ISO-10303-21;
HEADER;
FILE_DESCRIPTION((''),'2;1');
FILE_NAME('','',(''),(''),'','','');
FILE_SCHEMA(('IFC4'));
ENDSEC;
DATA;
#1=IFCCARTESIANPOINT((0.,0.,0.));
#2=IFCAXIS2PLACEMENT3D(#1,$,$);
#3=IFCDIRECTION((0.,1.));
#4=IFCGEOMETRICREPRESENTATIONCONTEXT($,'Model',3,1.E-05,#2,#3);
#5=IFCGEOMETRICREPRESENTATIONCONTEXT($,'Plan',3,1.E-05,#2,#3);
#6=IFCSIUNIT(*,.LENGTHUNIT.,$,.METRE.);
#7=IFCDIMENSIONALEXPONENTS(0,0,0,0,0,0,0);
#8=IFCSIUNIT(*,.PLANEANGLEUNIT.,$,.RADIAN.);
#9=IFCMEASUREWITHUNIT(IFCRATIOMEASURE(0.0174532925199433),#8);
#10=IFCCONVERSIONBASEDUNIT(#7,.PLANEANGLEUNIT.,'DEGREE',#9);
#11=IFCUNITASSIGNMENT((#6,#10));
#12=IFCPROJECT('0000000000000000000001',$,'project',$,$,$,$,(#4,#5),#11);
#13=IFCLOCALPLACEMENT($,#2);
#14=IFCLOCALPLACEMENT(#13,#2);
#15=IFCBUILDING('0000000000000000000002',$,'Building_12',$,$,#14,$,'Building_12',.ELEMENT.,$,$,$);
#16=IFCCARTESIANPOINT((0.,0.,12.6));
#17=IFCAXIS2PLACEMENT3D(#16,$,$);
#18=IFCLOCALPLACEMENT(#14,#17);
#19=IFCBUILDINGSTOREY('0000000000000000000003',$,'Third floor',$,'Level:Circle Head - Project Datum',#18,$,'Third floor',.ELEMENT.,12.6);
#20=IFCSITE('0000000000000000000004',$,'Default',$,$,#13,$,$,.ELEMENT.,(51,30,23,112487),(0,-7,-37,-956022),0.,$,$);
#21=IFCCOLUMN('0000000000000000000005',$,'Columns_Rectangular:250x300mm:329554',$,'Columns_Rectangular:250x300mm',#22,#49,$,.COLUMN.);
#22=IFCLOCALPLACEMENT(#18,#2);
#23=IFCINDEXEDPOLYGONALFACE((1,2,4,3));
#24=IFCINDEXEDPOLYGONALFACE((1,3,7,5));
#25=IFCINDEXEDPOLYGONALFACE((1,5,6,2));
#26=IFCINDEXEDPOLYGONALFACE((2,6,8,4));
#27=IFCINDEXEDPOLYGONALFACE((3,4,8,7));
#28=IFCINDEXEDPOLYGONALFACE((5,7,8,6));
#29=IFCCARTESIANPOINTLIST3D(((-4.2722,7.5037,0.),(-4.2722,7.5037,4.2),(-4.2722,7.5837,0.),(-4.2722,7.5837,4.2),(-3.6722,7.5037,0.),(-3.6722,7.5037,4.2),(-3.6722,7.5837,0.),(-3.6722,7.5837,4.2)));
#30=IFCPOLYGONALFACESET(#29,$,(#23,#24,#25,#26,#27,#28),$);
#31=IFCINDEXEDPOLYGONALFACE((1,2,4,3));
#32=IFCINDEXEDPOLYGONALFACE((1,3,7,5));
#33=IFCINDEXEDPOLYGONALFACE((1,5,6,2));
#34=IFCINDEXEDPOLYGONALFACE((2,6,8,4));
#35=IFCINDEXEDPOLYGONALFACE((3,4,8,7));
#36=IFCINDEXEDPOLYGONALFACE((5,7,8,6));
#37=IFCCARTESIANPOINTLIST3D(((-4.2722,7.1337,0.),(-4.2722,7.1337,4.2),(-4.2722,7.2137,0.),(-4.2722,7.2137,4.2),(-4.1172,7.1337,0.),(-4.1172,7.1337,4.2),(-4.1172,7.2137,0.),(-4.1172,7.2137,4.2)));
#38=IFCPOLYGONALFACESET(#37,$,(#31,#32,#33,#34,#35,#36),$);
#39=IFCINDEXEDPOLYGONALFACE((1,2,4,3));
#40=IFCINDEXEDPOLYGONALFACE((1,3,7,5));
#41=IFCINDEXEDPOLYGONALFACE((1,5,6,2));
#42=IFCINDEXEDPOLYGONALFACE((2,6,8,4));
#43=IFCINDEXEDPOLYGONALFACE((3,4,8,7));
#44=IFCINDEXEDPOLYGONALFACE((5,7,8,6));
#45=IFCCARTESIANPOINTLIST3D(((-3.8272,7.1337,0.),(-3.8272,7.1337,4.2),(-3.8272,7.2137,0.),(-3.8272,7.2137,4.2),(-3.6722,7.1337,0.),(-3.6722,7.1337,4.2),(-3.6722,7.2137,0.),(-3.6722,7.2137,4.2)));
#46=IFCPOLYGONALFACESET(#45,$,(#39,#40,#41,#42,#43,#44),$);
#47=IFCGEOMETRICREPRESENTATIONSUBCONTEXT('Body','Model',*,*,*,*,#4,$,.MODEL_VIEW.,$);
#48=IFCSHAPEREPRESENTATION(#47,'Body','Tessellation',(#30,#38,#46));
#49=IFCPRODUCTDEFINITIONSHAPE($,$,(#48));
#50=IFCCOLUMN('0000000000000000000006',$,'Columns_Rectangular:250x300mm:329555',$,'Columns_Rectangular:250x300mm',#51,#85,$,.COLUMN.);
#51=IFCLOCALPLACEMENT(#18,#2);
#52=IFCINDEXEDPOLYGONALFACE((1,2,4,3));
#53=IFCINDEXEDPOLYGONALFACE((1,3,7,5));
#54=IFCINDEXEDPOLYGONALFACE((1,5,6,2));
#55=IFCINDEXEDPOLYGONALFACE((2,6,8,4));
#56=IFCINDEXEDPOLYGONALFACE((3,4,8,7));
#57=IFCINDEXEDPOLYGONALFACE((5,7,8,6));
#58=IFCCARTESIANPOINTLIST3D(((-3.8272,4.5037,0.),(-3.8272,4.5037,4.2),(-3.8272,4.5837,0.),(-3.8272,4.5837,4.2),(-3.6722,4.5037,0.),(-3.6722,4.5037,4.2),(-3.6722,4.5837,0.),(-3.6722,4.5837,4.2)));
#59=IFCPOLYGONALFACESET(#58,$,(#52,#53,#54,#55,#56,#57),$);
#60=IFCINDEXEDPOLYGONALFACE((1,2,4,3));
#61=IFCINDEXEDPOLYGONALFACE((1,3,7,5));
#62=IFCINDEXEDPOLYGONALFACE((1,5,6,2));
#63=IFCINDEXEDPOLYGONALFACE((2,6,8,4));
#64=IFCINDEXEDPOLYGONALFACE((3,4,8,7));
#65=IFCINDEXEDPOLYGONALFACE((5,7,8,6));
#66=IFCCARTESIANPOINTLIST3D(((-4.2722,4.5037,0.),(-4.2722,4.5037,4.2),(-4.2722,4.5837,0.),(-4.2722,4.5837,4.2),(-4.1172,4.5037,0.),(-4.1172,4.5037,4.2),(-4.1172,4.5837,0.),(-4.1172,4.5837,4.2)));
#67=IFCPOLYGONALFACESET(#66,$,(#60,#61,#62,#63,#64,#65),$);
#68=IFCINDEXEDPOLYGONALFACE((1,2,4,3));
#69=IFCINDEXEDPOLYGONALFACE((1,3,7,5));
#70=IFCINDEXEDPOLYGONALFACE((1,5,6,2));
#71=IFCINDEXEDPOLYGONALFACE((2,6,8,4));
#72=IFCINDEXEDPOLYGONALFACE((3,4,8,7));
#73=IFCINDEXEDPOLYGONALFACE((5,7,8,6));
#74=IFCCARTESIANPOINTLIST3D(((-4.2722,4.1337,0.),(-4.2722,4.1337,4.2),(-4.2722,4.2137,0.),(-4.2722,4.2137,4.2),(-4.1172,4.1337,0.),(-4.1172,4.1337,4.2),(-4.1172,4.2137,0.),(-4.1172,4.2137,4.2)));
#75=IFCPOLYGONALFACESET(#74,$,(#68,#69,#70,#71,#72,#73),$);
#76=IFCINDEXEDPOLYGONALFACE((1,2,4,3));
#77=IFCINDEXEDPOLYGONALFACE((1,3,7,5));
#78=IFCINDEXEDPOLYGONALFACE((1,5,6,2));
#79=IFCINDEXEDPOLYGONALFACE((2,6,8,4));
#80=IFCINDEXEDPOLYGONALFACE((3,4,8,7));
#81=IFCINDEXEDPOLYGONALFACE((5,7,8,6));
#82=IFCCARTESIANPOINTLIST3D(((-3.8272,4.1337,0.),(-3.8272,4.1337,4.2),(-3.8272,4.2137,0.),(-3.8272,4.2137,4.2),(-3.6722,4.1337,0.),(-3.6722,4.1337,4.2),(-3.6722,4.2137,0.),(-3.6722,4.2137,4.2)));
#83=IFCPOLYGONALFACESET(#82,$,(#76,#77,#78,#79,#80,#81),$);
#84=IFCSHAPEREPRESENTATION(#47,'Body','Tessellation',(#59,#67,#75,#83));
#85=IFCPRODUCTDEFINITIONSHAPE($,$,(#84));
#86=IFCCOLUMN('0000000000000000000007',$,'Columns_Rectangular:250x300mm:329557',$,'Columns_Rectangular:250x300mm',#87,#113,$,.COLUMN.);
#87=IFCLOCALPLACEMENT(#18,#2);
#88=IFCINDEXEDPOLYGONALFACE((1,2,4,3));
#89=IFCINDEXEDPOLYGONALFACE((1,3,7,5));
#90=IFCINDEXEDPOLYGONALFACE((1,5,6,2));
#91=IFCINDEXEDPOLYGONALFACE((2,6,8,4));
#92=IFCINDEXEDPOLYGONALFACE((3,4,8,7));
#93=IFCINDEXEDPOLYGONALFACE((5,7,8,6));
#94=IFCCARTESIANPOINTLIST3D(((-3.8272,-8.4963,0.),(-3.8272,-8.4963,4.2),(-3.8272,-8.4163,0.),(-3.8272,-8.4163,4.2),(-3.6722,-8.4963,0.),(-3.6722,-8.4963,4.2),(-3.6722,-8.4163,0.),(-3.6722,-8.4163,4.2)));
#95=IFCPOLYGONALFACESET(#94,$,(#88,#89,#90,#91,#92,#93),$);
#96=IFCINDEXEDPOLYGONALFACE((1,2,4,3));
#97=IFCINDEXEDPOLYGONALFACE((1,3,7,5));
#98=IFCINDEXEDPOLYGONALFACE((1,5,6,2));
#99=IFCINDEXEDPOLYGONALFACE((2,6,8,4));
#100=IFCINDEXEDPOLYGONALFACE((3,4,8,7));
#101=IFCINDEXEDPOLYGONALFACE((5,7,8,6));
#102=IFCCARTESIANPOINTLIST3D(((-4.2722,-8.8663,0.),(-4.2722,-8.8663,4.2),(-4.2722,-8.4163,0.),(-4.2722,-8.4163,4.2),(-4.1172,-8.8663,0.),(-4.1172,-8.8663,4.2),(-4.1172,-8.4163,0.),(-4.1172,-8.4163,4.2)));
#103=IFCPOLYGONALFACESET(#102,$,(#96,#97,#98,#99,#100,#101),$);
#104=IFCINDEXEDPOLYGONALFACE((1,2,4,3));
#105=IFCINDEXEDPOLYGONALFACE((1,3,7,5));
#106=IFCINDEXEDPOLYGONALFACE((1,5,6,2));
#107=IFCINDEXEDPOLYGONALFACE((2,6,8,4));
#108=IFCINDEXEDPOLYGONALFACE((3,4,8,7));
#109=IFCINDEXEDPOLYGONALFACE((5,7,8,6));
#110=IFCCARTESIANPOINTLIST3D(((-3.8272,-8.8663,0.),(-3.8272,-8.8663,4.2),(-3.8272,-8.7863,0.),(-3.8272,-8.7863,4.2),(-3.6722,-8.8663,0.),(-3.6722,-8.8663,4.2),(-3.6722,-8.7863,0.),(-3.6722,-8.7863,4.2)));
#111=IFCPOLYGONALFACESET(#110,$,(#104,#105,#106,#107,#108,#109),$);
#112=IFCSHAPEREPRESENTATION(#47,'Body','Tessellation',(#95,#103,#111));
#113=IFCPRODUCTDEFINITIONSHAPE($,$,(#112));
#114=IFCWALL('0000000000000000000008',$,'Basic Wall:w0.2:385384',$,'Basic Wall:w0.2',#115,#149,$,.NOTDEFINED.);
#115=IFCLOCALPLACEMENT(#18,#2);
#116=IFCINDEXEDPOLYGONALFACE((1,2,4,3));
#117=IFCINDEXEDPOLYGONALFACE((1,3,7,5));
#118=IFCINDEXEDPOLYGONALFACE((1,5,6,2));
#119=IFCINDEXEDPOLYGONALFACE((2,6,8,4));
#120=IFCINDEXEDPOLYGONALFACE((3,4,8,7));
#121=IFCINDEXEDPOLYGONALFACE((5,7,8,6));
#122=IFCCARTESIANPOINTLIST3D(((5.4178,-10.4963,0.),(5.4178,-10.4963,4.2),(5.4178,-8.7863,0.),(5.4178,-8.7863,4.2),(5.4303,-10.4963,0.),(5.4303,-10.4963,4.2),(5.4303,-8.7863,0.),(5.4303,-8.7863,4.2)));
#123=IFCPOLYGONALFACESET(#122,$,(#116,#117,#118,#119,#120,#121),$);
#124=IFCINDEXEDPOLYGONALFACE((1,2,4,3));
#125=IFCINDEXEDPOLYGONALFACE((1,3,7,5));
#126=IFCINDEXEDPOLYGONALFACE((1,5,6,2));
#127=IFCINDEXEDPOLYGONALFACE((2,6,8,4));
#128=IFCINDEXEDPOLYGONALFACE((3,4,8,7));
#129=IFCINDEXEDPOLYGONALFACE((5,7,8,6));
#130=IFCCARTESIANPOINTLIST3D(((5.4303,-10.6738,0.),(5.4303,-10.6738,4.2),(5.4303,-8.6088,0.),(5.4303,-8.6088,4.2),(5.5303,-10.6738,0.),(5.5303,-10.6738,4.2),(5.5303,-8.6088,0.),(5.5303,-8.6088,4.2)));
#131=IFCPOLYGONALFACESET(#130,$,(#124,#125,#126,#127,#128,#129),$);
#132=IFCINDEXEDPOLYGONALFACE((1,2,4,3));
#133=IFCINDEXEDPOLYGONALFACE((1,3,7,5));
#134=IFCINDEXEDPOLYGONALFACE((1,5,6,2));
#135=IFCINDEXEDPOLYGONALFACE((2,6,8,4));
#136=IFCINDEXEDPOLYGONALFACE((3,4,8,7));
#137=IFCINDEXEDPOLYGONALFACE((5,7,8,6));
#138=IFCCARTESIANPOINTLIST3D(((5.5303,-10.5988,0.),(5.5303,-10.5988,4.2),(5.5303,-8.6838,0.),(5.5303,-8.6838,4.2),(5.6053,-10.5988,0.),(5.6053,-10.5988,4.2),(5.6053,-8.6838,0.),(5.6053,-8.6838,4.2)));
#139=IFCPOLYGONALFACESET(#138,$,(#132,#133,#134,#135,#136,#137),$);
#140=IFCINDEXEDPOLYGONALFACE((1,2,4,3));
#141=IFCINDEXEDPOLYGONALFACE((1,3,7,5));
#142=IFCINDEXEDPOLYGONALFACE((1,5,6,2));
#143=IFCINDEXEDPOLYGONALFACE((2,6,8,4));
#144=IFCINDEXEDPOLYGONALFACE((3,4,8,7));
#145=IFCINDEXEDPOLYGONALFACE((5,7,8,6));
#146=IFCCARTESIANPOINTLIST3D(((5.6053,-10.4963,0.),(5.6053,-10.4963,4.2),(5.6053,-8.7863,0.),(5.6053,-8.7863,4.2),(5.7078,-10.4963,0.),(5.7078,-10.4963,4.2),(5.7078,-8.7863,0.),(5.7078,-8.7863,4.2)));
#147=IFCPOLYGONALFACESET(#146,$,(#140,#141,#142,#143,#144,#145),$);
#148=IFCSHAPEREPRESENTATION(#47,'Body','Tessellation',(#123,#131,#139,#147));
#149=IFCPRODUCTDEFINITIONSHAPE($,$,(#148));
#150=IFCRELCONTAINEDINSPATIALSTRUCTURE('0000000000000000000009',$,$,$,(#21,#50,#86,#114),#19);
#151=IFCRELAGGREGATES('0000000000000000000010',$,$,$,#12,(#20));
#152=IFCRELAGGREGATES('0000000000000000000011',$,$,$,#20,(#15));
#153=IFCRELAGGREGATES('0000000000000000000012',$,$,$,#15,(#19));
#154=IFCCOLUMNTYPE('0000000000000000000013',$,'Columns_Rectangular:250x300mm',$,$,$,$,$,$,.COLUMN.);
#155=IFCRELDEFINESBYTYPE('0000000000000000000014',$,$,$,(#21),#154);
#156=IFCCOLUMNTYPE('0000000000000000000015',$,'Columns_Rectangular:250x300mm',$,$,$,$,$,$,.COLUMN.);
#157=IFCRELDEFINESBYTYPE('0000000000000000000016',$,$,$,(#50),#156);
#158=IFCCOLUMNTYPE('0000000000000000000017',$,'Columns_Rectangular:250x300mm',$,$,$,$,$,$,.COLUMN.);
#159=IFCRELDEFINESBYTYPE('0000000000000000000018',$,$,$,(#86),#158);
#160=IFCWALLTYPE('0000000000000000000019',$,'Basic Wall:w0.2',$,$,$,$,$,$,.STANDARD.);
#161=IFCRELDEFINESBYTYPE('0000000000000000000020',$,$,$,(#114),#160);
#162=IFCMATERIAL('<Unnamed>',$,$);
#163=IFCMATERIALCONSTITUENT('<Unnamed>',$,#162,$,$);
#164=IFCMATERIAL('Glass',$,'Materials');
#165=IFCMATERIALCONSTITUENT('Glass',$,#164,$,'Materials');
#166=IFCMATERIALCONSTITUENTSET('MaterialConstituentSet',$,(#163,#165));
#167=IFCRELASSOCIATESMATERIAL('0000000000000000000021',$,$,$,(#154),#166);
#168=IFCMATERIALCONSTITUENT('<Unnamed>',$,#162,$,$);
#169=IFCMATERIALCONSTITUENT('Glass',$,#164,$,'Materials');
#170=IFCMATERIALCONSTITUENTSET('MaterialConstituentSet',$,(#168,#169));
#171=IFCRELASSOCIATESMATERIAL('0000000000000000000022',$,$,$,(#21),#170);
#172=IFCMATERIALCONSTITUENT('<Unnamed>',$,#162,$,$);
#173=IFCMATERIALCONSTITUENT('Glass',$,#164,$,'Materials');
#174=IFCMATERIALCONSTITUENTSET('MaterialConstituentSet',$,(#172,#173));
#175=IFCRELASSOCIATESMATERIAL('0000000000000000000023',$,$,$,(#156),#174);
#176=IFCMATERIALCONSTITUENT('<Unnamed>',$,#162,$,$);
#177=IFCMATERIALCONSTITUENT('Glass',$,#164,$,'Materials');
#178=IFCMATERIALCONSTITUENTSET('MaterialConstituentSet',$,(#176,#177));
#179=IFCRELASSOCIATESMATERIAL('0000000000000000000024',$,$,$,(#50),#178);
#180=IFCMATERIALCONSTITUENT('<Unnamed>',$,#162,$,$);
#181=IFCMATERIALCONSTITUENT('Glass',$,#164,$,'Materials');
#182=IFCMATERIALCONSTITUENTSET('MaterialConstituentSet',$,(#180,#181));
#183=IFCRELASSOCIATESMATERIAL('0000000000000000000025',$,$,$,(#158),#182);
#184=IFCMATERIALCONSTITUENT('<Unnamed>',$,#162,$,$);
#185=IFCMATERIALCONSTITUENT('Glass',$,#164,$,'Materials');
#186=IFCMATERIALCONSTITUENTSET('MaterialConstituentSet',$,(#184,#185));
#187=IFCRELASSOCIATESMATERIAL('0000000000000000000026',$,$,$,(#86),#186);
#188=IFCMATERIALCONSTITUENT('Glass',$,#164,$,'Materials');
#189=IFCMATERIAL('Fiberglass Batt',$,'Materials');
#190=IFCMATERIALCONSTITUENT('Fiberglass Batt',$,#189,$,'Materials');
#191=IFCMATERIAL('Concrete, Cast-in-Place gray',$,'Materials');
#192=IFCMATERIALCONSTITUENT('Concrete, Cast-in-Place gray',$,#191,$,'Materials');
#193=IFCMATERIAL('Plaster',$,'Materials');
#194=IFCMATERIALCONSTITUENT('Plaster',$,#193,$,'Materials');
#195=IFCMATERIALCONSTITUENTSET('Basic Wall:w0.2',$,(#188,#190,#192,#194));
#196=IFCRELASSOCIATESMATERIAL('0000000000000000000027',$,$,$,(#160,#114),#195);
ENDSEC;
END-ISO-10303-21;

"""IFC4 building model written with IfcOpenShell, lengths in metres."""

from ifc_helpers import new_model, entity, si_unit, converted_unit, direction, frame, origin, place, context, subcontext, project, spatial, indexed_curve, outline, extrude, source, transform, mapped, material, constituent, constituent_set, type_object, type_shapes, element, save


model = new_model("IFC4")

# Units and contexts
model_context = context("Model", 3, precision=1e-05, world=origin(), true_north=direction((0.0, 1.0)))
plan_context = context("Plan", 3, precision=1e-05, world=origin(), true_north=direction((0.0, 1.0)))
body_context = subcontext(model_context, "Body", "Model", "MODEL_VIEW")
ifc_project = project(units=[si_unit("LENGTHUNIT", "METRE"), converted_unit("PLANEANGLEUNIT", "DEGREE", entity("IfcRatioMeasure", 0.0174532925199433), si_unit("PLANEANGLEUNIT", "RADIAN"), dimensions=[0, 0, 0, 0, 0, 0, 0])], contexts=[model_context, plan_context])

# Site, building, storey
site_placement = place(None, origin())
site = spatial("IfcSite", under=ifc_project, at=site_placement, Name="Default", CompositionType="ELEMENT", RefLatitude=(51, 30, 23, 112487), RefLongitude=(0, -7, -37, -956022), RefElevation=0.0)
building_placement = place(site_placement, origin())
building = spatial("IfcBuilding", under=site, at=building_placement, Name="Building_12", LongName="Building_12", CompositionType="ELEMENT")
storey_placement = place(building_placement, frame((0.0, 0.0, 12.6)))
storey = spatial("IfcBuildingStorey", under=building, at=storey_placement, Name="Third floor", ObjectType="Level:Circle Head - Project Datum", LongName="Third floor", CompositionType="ELEMENT", Elevation=12.6)

# Columns
ifc_material_1 = material(Name="<Unnamed>")
ifc_material_2 = material(Name="Plaster", Category="Materials")
ifc_constituent_1 = constituent(ifc_material_1, Name="<Unnamed>")
ifc_material_3 = material(Name="Glass", Category="Materials")
ifc_constituent_2 = constituent(ifc_material_3, Name="Glass", Category="Materials")
ifc_constituent_set_1 = constituent_set(constituents=[ifc_constituent_1, ifc_constituent_2], Name="MaterialConstituentSet")
ifc_constituent_3 = constituent(ifc_material_1, Name="<Unnamed>")
ifc_constituent_4 = constituent(ifc_material_3, Name="Glass", Category="Materials")
ifc_constituent_set_2 = constituent_set(constituents=[ifc_constituent_3, ifc_constituent_4], Name="MaterialConstituentSet")
column_type_1 = type_object("IfcColumnType", Name="Columns_Rectangular:250x300mm", PredefinedType="COLUMN", material=ifc_constituent_set_2)
shared_shape_1 = source(origin(), body_context, "Body", "SweptSolid", [
    extrude(outline(indexed_curve([(-0.04, -0.3), (0.04, -0.3), (0.04, 0.3), (-0.04, 0.3), (-0.04, -0.3)], self_intersect=False)), frame((-3.9722, 7.5437, 12.6), z_axis=(0.0, 0.0, 1.0), x_axis=(0.0, -1.0, 0.0)), (0.0, 0.0, 1.0), 4.2),
    extrude(outline(indexed_curve([(-0.04, -0.0775), (0.04, -0.0775), (0.04, 0.0775), (-0.04, 0.0775), (-0.04, -0.0775)], self_intersect=False)), frame((-4.1947, 7.1737, 12.6), z_axis=(0.0, 0.0, 1.0), x_axis=(0.0, -1.0, 0.0)), (0.0, 0.0, 1.0), 4.2),
    extrude(outline(indexed_curve([(-0.04, -0.0775), (0.04, -0.0775), (0.04, 0.0775), (-0.04, 0.0775), (-0.04, -0.0775)], self_intersect=False)), frame((-3.7497, 7.1737, 12.6), z_axis=(0.0, 0.0, 1.0), x_axis=(0.0, -1.0, 0.0)), (0.0, 0.0, 1.0), 4.2),
])
type_shapes(column_type_1, [shared_shape_1])
column_1_placement = place(storey_placement, frame((0.0, 0.0, -12.6)))
element("IfcColumn", 1, at=column_1_placement, inside=storey, type_object=column_type_1, material=ifc_constituent_set_1, Name="Columns_Rectangular:250x300mm:329554", ObjectType="Columns_Rectangular:250x300mm", PredefinedType="COLUMN", context=body_context, shape_type="MappedRepresentation", body=[
    mapped(shared_shape_1, transform((0.0, 0.0, 0.0), scale=1.0)),
])
ifc_constituent_5 = constituent(ifc_material_1, Name="<Unnamed>")
ifc_constituent_6 = constituent(ifc_material_3, Name="Glass", Category="Materials")
ifc_constituent_set_3 = constituent_set(constituents=[ifc_constituent_5, ifc_constituent_6], Name="MaterialConstituentSet")
ifc_constituent_7 = constituent(ifc_material_1, Name="<Unnamed>")
ifc_constituent_8 = constituent(ifc_material_3, Name="Glass", Category="Materials")
ifc_constituent_set_4 = constituent_set(constituents=[ifc_constituent_7, ifc_constituent_8], Name="MaterialConstituentSet")
column_type_2 = type_object("IfcColumnType", Name="Columns_Rectangular:250x300mm", PredefinedType="COLUMN", material=ifc_constituent_set_4)
shared_shape_2 = source(origin(), body_context, "Body", "SweptSolid", [
    extrude(outline(indexed_curve([(-0.04, -0.0775), (0.04, -0.0775), (0.04, 0.0775), (-0.04, 0.0775), (-0.04, -0.0775)], self_intersect=False)), frame((-3.7497, 4.5437, 12.6), z_axis=(0.0, 0.0, 1.0), x_axis=(0.0, -1.0, 0.0)), (0.0, 0.0, 1.0), 4.2),
    extrude(outline(indexed_curve([(-0.04, -0.0775), (0.04, -0.0775), (0.04, 0.0775), (-0.04, 0.0775), (-0.04, -0.0775)], self_intersect=False)), frame((-4.1947, 4.5437, 12.6), z_axis=(0.0, 0.0, 1.0), x_axis=(0.0, -1.0, 0.0)), (0.0, 0.0, 1.0), 4.2),
    extrude(outline(indexed_curve([(-0.04, -0.0775), (0.04, -0.0775), (0.04, 0.0775), (-0.04, 0.0775), (-0.04, -0.0775)], self_intersect=False)), frame((-4.1947, 4.1737, 12.6), z_axis=(0.0, 0.0, 1.0), x_axis=(0.0, -1.0, 0.0)), (0.0, 0.0, 1.0), 4.2),
    extrude(outline(indexed_curve([(-0.04, -0.0775), (0.04, -0.0775), (0.04, 0.0775), (-0.04, 0.0775), (-0.04, -0.0775)], self_intersect=False)), frame((-3.7497, 4.1737, 12.6), z_axis=(0.0, 0.0, 1.0), x_axis=(0.0, -1.0, 0.0)), (0.0, 0.0, 1.0), 4.2),
])
type_shapes(column_type_2, [shared_shape_2])
column_2_placement = place(storey_placement, frame((0.0, 0.0, -12.6)))
element("IfcColumn", 2, at=column_2_placement, inside=storey, type_object=column_type_2, material=ifc_constituent_set_3, Name="Columns_Rectangular:250x300mm:329555", ObjectType="Columns_Rectangular:250x300mm", PredefinedType="COLUMN", context=body_context, shape_type="MappedRepresentation", body=[
    mapped(shared_shape_2, transform((0.0, 0.0, 0.0), scale=1.0)),
])
ifc_constituent_9 = constituent(ifc_material_1, Name="<Unnamed>")
ifc_constituent_10 = constituent(ifc_material_3, Name="Glass", Category="Materials")
ifc_constituent_set_5 = constituent_set(constituents=[ifc_constituent_9, ifc_constituent_10], Name="MaterialConstituentSet")
ifc_constituent_11 = constituent(ifc_material_1, Name="<Unnamed>")
ifc_constituent_12 = constituent(ifc_material_3, Name="Glass", Category="Materials")
ifc_constituent_set_6 = constituent_set(constituents=[ifc_constituent_11, ifc_constituent_12], Name="MaterialConstituentSet")
column_type_3 = type_object("IfcColumnType", Name="Columns_Rectangular:250x300mm", PredefinedType="COLUMN", material=ifc_constituent_set_6)
shared_shape_3 = source(origin(), body_context, "Body", "SweptSolid", [
    extrude(outline(indexed_curve([(-0.04, -0.0775), (0.04, -0.0775), (0.04, 0.0775), (-0.04, 0.0775), (-0.04, -0.0775)], self_intersect=False)), frame((-3.7497, -8.4563, 12.6), z_axis=(0.0, 0.0, 1.0), x_axis=(0.0, -1.0, 0.0)), (0.0, 0.0, 1.0), 4.2),
    extrude(outline(indexed_curve([(-0.225, -0.0775), (0.225, -0.0775), (0.225, 0.0775), (-0.225, 0.0775), (-0.225, -0.0775)], self_intersect=False)), frame((-4.1947, -8.6413, 12.6), z_axis=(0.0, 0.0, 1.0), x_axis=(0.0, -1.0, 0.0)), (0.0, 0.0, 1.0), 4.2),
    extrude(outline(indexed_curve([(-0.04, -0.0775), (0.04, -0.0775), (0.04, 0.0775), (-0.04, 0.0775), (-0.04, -0.0775)], self_intersect=False)), frame((-3.7497, -8.8263, 12.6), z_axis=(0.0, 0.0, 1.0), x_axis=(0.0, -1.0, 0.0)), (0.0, 0.0, 1.0), 4.2),
])
type_shapes(column_type_3, [shared_shape_3])
column_3_placement = place(storey_placement, frame((0.0, 0.0, -12.6)))
element("IfcColumn", 3, at=column_3_placement, inside=storey, type_object=column_type_3, material=ifc_constituent_set_5, Name="Columns_Rectangular:250x300mm:329557", ObjectType="Columns_Rectangular:250x300mm", PredefinedType="COLUMN", context=body_context, shape_type="MappedRepresentation", body=[
    mapped(shared_shape_3, transform((0.0, 0.0, 0.0), scale=1.0)),
])

# Shared definitions
ifc_constituent_13 = constituent(ifc_material_3, Name="Glass", Category="Materials")
ifc_material_4 = material(Name="Fiberglass Batt", Category="Materials")
ifc_constituent_14 = constituent(ifc_material_4, Name="Fiberglass Batt", Category="Materials")
ifc_material_5 = material(Name="Concrete, Cast-in-Place gray", Category="Materials")
ifc_constituent_15 = constituent(ifc_material_5, Name="Concrete, Cast-in-Place gray", Category="Materials")
ifc_constituent_16 = constituent(ifc_material_2, Name="Plaster", Category="Materials")
ifc_constituent_set_7 = constituent_set(constituents=[ifc_constituent_13, ifc_constituent_14, ifc_constituent_15, ifc_constituent_16], Name="Basic Wall:w0.2")
wall_type = type_object("IfcWallType", Name="Basic Wall:w0.2", PredefinedType="STANDARD", material=ifc_constituent_set_7)

# Wall
wall_1_placement = place(storey_placement, frame((5.5628, -8.7863, 0.0), z_axis=(0.0, 0.0, 1.0), x_axis=(0.0, -1.0, 0.0)))
element("IfcWall", 4, at=wall_1_placement, inside=storey, type_object=wall_type, material=ifc_constituent_set_7, Name="Basic Wall:w0.2:385384", ObjectType="Basic Wall:w0.2", PredefinedType="NOTDEFINED", context=body_context, shape_type="SweptSolid", body=[
    extrude(outline(indexed_curve([(-0.0063, -0.855), (0.0062, -0.855), (0.0063, 0.855), (-0.0062, 0.855), (-0.0063, -0.855)], self_intersect=False)), frame((0.855, -0.1388, 0.0), z_axis=(0.0, 0.0, 1.0), x_axis=(0.0, 1.0, 0.0)), (0.0, 0.0, 1.0), 4.2),
    extrude(outline(indexed_curve([(-1.0325, -0.05), (1.0325, -0.05), (1.0325, 0.05), (-1.0325, 0.05), (-1.0325, -0.05)], self_intersect=False)), frame((0.855, -0.0825, 0.0)), (0.0, 0.0, 1.0), 4.2),
    extrude(outline(indexed_curve([(-0.9575, -0.0375), (0.9575, -0.0375), (0.9575, 0.0375), (-0.9575, 0.0375), (-0.9575, -0.0375)], self_intersect=False)), frame((0.855, 0.005, 0.0)), (0.0, 0.0, 1.0), 4.2),
    extrude(outline(indexed_curve([(-0.0513, -0.855), (0.0512, -0.855), (0.0513, 0.855), (-0.0512, 0.855), (-0.0513, -0.855)], self_intersect=False)), frame((0.855, 0.0937, 0.0), z_axis=(0.0, 0.0, 1.0), x_axis=(0.0, -1.0, 0.0)), (0.0, 0.0, 1.0), 4.2),
])

save(model, "model.ifc")
